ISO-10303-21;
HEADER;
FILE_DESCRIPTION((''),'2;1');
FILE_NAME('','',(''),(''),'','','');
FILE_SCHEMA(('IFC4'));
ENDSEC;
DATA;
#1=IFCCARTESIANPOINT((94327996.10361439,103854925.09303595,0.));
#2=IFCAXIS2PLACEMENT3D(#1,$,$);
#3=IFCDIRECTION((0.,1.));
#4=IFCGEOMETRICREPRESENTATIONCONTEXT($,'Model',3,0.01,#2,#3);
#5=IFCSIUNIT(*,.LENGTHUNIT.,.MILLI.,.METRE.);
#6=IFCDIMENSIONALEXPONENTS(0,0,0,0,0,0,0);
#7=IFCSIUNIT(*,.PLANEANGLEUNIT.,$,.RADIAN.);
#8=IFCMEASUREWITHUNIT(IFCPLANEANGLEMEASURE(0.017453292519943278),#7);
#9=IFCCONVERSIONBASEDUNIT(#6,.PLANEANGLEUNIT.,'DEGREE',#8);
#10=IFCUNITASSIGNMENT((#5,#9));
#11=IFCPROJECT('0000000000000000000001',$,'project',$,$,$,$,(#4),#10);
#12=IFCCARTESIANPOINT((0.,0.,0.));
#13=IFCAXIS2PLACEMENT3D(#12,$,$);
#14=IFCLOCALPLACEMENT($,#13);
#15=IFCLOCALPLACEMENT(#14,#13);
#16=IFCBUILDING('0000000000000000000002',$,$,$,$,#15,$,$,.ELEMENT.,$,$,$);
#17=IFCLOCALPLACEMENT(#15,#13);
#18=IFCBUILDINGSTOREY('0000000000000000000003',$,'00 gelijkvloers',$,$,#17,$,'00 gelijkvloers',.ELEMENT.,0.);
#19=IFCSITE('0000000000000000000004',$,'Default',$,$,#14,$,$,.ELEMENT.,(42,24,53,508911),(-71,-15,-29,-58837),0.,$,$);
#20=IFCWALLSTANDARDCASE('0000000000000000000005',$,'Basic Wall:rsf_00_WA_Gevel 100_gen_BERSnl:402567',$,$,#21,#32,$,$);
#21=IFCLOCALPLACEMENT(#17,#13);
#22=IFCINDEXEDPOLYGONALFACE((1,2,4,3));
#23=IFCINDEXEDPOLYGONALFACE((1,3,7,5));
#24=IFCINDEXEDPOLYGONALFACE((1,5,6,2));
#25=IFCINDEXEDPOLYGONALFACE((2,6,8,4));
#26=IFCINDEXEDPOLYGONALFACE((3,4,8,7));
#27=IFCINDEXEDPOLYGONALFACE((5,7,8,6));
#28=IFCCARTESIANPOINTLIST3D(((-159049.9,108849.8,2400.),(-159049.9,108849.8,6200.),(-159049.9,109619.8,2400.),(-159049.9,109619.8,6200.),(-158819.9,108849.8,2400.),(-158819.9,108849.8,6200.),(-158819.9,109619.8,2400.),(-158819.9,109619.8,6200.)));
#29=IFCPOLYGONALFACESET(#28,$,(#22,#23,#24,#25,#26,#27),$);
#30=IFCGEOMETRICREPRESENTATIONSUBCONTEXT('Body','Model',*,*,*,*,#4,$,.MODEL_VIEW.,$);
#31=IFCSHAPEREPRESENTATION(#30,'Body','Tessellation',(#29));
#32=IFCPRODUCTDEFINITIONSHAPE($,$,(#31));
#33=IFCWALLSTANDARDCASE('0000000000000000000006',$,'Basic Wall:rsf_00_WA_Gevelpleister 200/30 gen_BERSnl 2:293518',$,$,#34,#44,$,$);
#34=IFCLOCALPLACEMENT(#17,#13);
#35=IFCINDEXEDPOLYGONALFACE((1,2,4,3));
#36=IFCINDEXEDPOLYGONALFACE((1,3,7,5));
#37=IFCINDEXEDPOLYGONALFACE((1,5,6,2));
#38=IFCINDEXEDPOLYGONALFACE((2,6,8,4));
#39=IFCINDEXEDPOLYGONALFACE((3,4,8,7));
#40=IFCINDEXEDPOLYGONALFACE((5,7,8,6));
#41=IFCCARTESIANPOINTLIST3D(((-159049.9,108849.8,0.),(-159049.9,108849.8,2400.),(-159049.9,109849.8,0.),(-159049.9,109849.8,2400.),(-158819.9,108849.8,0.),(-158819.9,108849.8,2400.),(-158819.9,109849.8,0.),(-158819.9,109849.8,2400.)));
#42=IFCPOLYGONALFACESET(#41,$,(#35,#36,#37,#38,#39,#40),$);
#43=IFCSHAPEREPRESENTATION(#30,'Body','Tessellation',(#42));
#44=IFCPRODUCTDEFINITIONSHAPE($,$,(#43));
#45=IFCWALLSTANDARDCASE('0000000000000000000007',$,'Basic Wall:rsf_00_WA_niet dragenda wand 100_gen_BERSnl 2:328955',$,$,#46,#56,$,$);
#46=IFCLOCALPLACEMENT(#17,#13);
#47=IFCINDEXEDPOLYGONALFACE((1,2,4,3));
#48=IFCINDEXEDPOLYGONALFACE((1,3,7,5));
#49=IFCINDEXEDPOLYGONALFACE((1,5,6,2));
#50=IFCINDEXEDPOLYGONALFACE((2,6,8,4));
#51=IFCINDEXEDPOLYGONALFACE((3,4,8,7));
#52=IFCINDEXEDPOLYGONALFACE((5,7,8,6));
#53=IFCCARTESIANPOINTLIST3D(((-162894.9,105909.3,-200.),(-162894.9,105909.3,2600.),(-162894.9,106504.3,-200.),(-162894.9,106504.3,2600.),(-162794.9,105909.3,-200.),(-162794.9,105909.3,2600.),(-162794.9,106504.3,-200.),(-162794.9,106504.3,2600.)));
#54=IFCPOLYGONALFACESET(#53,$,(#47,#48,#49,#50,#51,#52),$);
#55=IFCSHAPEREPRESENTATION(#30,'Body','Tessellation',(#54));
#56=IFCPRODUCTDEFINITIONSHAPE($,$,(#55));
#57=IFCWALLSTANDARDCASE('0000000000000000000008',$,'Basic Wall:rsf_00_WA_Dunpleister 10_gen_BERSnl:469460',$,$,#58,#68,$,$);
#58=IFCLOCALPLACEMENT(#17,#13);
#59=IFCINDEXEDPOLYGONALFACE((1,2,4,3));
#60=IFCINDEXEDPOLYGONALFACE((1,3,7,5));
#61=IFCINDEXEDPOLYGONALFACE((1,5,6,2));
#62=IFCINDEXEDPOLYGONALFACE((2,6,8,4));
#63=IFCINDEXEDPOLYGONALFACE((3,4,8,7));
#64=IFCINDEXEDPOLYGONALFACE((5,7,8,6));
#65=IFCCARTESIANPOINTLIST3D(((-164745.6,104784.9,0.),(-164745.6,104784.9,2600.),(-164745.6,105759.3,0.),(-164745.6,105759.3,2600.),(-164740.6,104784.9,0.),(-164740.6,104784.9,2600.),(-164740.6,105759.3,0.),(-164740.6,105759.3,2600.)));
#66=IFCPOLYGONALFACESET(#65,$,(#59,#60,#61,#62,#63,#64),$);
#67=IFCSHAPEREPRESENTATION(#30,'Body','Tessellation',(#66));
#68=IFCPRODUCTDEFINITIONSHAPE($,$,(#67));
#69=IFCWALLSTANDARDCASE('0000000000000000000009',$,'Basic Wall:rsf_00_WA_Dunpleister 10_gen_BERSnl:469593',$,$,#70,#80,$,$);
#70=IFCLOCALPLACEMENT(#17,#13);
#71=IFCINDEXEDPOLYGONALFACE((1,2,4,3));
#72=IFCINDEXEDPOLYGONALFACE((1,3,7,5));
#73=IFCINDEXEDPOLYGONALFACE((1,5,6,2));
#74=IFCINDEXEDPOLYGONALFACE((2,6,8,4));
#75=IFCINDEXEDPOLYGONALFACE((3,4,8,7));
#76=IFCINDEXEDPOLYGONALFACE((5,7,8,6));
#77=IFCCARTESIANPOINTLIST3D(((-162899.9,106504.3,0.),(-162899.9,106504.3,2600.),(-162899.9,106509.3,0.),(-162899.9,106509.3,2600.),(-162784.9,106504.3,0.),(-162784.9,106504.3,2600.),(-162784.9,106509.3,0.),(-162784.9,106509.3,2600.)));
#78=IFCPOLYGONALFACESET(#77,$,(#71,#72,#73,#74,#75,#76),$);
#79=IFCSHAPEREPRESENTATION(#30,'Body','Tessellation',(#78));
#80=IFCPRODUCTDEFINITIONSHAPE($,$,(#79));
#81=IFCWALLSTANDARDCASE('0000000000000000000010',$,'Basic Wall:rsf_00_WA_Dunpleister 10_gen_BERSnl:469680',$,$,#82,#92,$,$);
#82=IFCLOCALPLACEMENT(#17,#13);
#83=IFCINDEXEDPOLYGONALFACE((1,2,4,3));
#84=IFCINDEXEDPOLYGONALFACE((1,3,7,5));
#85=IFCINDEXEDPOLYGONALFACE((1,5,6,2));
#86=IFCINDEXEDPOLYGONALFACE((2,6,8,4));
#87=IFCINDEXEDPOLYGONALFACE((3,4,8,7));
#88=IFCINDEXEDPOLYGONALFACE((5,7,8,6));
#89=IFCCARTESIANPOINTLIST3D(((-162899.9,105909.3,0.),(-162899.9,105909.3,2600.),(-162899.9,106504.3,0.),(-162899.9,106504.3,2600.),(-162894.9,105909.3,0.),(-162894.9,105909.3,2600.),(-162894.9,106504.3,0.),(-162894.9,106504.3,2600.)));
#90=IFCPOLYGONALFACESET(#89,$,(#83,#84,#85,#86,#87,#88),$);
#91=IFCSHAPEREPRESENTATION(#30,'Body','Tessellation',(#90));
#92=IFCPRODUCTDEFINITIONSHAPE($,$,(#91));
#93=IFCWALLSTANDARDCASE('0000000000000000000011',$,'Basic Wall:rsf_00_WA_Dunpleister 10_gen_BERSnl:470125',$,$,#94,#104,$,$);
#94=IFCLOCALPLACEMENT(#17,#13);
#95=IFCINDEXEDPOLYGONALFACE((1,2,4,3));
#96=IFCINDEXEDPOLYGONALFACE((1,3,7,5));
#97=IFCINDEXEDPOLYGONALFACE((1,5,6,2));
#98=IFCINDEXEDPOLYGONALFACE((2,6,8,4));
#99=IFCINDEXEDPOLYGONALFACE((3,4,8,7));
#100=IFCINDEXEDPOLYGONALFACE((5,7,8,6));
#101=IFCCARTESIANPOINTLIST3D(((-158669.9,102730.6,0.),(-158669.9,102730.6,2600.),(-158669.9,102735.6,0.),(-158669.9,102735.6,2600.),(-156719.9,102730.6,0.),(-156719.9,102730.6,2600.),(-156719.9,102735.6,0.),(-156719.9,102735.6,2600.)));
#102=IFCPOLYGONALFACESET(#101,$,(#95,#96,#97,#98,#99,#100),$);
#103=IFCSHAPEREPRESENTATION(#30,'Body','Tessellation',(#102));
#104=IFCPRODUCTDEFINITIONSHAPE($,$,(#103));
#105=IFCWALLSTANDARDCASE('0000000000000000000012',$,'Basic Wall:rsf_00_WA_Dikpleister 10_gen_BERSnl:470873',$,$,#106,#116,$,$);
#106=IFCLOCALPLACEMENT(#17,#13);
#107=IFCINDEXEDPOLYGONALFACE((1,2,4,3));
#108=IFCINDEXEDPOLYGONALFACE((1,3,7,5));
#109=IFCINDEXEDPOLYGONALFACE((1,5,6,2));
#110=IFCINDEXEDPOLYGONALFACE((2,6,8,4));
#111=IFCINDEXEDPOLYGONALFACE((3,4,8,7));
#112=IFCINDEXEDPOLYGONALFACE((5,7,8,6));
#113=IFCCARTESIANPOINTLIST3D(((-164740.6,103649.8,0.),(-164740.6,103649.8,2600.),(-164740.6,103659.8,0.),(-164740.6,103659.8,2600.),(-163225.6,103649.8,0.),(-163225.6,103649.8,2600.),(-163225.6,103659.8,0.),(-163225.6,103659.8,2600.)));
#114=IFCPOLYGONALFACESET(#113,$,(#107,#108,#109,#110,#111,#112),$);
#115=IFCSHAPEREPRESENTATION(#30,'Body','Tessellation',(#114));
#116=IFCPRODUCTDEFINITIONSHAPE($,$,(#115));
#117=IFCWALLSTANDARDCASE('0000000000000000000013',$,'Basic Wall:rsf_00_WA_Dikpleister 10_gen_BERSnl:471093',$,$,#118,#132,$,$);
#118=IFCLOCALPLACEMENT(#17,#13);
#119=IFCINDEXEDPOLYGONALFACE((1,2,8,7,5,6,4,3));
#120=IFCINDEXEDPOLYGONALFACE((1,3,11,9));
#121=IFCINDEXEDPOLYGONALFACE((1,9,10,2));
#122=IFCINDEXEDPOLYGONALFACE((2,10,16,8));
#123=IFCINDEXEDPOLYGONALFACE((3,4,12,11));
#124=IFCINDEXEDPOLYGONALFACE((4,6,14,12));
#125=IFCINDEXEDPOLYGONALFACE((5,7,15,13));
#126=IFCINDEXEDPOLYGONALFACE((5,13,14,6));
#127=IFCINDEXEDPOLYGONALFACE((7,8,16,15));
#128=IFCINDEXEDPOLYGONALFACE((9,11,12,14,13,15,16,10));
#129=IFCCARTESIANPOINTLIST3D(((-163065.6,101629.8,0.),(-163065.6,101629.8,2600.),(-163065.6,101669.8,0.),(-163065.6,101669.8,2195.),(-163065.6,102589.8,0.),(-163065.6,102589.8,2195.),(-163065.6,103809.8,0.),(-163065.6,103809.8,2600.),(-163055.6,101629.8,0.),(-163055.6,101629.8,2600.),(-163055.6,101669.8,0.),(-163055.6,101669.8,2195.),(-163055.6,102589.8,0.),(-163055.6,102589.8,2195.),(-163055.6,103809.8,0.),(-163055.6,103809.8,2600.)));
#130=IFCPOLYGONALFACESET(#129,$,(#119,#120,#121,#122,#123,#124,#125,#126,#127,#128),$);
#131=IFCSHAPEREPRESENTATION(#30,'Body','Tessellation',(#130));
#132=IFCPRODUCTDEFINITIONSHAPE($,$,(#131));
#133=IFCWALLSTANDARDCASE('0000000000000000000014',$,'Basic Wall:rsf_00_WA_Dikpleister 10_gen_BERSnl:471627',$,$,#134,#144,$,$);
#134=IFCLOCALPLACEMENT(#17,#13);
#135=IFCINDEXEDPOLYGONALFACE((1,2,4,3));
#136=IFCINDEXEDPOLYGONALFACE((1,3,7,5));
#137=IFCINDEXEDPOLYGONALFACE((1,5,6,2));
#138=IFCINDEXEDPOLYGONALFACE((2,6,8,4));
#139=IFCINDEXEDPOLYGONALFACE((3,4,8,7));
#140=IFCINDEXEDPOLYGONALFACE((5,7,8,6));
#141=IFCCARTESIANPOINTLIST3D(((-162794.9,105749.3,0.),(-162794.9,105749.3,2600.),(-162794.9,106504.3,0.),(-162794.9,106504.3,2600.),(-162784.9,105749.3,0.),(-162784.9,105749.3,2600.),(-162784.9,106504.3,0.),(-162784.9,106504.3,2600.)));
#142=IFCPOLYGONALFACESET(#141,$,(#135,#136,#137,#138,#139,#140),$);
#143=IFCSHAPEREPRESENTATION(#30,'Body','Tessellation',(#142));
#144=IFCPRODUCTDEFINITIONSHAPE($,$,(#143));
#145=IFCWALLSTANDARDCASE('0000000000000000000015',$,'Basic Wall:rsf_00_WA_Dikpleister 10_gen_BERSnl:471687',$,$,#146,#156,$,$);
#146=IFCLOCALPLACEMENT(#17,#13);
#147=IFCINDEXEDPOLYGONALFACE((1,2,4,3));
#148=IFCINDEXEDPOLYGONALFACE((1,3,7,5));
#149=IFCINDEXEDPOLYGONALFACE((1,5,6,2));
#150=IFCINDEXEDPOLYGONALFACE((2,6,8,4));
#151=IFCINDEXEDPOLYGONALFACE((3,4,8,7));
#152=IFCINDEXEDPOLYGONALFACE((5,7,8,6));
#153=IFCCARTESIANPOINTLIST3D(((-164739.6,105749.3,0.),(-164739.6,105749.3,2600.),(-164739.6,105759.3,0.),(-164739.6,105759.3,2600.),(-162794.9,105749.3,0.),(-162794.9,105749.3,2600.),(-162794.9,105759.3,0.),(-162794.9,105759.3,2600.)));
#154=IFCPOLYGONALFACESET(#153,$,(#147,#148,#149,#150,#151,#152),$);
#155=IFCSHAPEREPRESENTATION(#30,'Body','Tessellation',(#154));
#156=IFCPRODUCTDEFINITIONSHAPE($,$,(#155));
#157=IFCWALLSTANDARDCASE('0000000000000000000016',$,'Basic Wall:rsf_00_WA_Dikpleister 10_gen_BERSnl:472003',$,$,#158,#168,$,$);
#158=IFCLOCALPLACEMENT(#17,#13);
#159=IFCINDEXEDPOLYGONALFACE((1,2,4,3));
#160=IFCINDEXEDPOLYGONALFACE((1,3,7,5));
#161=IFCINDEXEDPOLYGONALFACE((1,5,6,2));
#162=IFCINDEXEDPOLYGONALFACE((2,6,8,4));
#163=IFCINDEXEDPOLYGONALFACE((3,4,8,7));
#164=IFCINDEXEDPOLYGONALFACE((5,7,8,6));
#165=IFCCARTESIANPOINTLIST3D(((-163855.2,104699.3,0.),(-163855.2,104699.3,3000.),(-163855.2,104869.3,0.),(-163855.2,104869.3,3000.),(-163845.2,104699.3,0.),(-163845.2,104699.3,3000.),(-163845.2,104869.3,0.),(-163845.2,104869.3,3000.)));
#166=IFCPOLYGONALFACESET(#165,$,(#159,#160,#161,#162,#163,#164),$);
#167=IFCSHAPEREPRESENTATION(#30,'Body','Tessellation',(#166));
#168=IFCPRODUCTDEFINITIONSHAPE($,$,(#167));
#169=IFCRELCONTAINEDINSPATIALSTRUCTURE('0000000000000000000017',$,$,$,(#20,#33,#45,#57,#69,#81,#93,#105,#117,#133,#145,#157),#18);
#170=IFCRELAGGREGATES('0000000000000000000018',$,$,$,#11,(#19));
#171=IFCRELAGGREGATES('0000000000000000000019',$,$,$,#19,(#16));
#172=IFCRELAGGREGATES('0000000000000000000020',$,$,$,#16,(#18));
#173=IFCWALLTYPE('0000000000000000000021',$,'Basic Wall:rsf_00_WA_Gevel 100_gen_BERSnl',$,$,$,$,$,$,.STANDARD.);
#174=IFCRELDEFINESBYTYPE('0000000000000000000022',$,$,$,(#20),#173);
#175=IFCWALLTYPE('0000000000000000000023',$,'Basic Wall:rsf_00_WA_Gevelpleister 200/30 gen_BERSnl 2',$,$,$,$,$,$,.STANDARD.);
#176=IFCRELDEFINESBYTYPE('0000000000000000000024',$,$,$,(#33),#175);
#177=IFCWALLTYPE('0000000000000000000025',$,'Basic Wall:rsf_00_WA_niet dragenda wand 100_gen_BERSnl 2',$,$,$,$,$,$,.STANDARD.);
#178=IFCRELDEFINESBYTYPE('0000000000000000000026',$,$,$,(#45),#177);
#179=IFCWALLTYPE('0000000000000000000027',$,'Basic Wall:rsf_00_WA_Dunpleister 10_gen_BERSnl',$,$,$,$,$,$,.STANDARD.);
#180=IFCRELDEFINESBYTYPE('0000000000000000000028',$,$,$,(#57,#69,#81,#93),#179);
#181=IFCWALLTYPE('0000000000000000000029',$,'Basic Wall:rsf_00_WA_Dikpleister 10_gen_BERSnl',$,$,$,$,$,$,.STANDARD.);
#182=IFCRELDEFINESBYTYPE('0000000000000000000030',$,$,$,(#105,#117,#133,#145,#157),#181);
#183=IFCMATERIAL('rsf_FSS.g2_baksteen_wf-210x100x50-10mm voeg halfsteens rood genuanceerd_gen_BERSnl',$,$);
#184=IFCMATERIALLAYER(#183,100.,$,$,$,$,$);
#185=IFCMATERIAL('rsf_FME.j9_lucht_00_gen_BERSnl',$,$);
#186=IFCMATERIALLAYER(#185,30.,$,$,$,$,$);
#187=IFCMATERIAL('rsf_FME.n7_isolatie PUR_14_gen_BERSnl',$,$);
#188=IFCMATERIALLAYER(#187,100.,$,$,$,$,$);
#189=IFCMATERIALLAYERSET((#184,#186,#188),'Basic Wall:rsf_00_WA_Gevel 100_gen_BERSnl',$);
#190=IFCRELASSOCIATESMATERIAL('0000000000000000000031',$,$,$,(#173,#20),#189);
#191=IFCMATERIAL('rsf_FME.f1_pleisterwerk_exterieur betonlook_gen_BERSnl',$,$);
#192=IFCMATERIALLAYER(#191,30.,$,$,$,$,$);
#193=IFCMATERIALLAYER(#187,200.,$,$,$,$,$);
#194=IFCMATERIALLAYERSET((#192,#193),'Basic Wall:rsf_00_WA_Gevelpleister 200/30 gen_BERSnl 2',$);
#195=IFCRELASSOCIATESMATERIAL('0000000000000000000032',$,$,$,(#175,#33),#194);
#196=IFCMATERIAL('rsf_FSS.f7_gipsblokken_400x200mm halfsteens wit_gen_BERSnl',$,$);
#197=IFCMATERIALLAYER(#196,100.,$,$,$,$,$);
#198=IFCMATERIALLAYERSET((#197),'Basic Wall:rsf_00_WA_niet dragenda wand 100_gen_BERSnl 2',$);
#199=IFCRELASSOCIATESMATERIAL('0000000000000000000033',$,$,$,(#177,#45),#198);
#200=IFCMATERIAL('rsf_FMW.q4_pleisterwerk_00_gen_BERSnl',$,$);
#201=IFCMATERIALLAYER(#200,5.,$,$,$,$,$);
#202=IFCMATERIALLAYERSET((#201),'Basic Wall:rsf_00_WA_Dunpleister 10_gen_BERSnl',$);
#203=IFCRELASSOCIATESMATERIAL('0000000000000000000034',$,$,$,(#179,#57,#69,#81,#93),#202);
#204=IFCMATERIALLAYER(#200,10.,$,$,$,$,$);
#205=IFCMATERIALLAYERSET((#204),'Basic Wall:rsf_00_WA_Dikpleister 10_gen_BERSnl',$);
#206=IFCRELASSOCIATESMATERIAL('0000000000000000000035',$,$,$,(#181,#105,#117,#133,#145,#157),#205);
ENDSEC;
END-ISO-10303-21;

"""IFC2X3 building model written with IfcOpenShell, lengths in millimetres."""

from ifc_helpers import new_model, entity, si_unit, converted_unit, direction, frame, frame_2d, origin, place, context, subcontext, project, spatial, rectangle, extrude, material, layer, layer_set, layer_usage, type_object, element, save


model = new_model("IFC2X3")

# Units and contexts
model_context = context("Model", 3, precision=0.01, world=frame((94327996.10361439, 103854925.09303595, 0.0)), true_north=direction((0.0, 1.0)))
body_context = subcontext(model_context, "Body", "Model", "MODEL_VIEW")
ifc_project = project(units=[si_unit("LENGTHUNIT", "METRE", prefix="MILLI"), converted_unit("PLANEANGLEUNIT", "DEGREE", entity("IfcPlaneAngleMeasure", 0.017453292519943278), si_unit("PLANEANGLEUNIT", "RADIAN"), dimensions=[0, 0, 0, 0, 0, 0, 0])], contexts=[model_context])

# Site, building, storey
site_placement = place(None, origin())
site = spatial("IfcSite", under=ifc_project, at=site_placement, Name="Default", CompositionType="ELEMENT", RefLatitude=(42, 24, 53, 508911), RefLongitude=(-71, -15, -29, -58837), RefElevation=0.0)
building_placement = place(site_placement, origin())
building = spatial("IfcBuilding", under=site, at=building_placement, CompositionType="ELEMENT")
storey_placement = place(building_placement, origin())
storey = spatial("IfcBuildingStorey", under=building, at=storey_placement, Name="00 gelijkvloers", LongName="00 gelijkvloers", CompositionType="ELEMENT", Elevation=0.0)

# Walls
ifc_material_1 = material(Name="rsf_FSS.g2_baksteen_wf-210x100x50-10mm voeg halfsteens rood genuanceerd_gen_BERSnl")
ifc_layer_1 = layer(ifc_material_1, 100.0)
ifc_material_2 = material(Name="rsf_FME.j9_lucht_00_gen_BERSnl")
ifc_layer_2 = layer(ifc_material_2, 30.0)
ifc_material_3 = material(Name="rsf_FME.n7_isolatie PUR_14_gen_BERSnl")
ifc_layer_3 = layer(ifc_material_3, 100.0)
ifc_layer_set_1 = layer_set([ifc_layer_1, ifc_layer_2, ifc_layer_3], Name="Basic Wall:rsf_00_WA_Gevel 100_gen_BERSnl")
ifc_layer_usage_1 = layer_usage(ifc_layer_set_1, "AXIS2", "NEGATIVE", 115.0)
wall_type_1 = type_object("IfcWallType", Name="Basic Wall:rsf_00_WA_Gevel 100_gen_BERSnl", PredefinedType="STANDARD", material=ifc_layer_set_1)
wall_1_placement = place(storey_placement, frame((-158934.9, 108849.8, 2400.0), z_axis=(0.0, 0.0, 1.0), x_axis=(0.0, 1.0, 0.0)))
element("IfcWallStandardCase", 1, at=wall_1_placement, inside=storey, type_object=wall_type_1, material=ifc_layer_usage_1, Name="Basic Wall:rsf_00_WA_Gevel 100_gen_BERSnl:402567", context=body_context, shape_type="SweptSolid", body=[
    extrude(rectangle(XDim=769.9, YDim=230.0, at=frame_2d((385.0, 0.0), x_axis=(-1.0, 0.0))), origin(), (0.0, 0.0, 1.0), 3800.0),
])
ifc_material_4 = material(Name="rsf_FME.f1_pleisterwerk_exterieur betonlook_gen_BERSnl")
ifc_layer_4 = layer(ifc_material_4, 30.0)
ifc_layer_5 = layer(ifc_material_3, 200.0)
ifc_layer_set_2 = layer_set([ifc_layer_4, ifc_layer_5], Name="Basic Wall:rsf_00_WA_Gevelpleister 200/30 gen_BERSnl 2")
ifc_layer_usage_2 = layer_usage(ifc_layer_set_2, "AXIS2", "NEGATIVE", 115.0)
wall_type_2 = type_object("IfcWallType", Name="Basic Wall:rsf_00_WA_Gevelpleister 200/30 gen_BERSnl 2", PredefinedType="STANDARD", material=ifc_layer_set_2)
wall_2_placement = place(storey_placement, frame((-158934.9, 108849.8, 0.0), z_axis=(0.0, 0.0, 1.0), x_axis=(0.0, 1.0, 0.0)))
element("IfcWallStandardCase", 2, at=wall_2_placement, inside=storey, type_object=wall_type_2, material=ifc_layer_usage_2, Name="Basic Wall:rsf_00_WA_Gevelpleister 200/30 gen_BERSnl 2:293518", context=body_context, shape_type="SweptSolid", body=[
    extrude(rectangle(XDim=999.9, YDim=230.0, at=frame_2d((500.0, 0.0), x_axis=(-1.0, 0.0))), origin(), (0.0, 0.0, 1.0), 2400.0),
])
ifc_material_5 = material(Name="rsf_FSS.f7_gipsblokken_400x200mm halfsteens wit_gen_BERSnl")
ifc_layer_6 = layer(ifc_material_5, 100.0)
ifc_layer_set_3 = layer_set([ifc_layer_6], Name="Basic Wall:rsf_00_WA_niet dragenda wand 100_gen_BERSnl 2")
ifc_layer_usage_3 = layer_usage(ifc_layer_set_3, "AXIS2", "NEGATIVE", 50.0)
wall_type_3 = type_object("IfcWallType", Name="Basic Wall:rsf_00_WA_niet dragenda wand 100_gen_BERSnl 2", PredefinedType="STANDARD", material=ifc_layer_set_3)
wall_3_placement = place(storey_placement, frame((-162844.9, 105909.3, -200.0), z_axis=(0.0, 0.0, 1.0), x_axis=(0.0, 1.0, 0.0)))
element("IfcWallStandardCase", 3, at=wall_3_placement, inside=storey, type_object=wall_type_3, material=ifc_layer_usage_3, Name="Basic Wall:rsf_00_WA_niet dragenda wand 100_gen_BERSnl 2:328955", context=body_context, shape_type="SweptSolid", body=[
    extrude(rectangle(XDim=595.0, YDim=100.0, at=frame_2d((297.5, 0.0), x_axis=(-1.0, 0.0))), origin(), (0.0, 0.0, 1.0), 2800.0),
])
ifc_material_6 = material(Name="rsf_FMW.q4_pleisterwerk_00_gen_BERSnl")
ifc_layer_7 = layer(ifc_material_6, 5.0)
ifc_layer_set_4 = layer_set([ifc_layer_7], Name="Basic Wall:rsf_00_WA_Dunpleister 10_gen_BERSnl")
ifc_layer_usage_4 = layer_usage(ifc_layer_set_4, "AXIS2", "NEGATIVE", 2.5)
wall_type_4 = type_object("IfcWallType", Name="Basic Wall:rsf_00_WA_Dunpleister 10_gen_BERSnl", PredefinedType="STANDARD", material=ifc_layer_set_4)
wall_4_placement = place(storey_placement, frame((-164743.1, 105759.3, 0.0), z_axis=(0.0, 0.0, 1.0), x_axis=(0.0, -1.0, 0.0)))
element("IfcWallStandardCase", 4, at=wall_4_placement, inside=storey, type_object=wall_type_4, material=ifc_layer_usage_4, Name="Basic Wall:rsf_00_WA_Dunpleister 10_gen_BERSnl:469460", context=body_context, shape_type="SweptSolid", body=[
    extrude(rectangle(XDim=974.4, YDim=5.0, at=frame_2d((487.2, 0.0), x_axis=(-1.0, 0.0))), origin(), (0.0, 0.0, 1.0), 2600.0),
])
ifc_layer_usage_5 = layer_usage(ifc_layer_set_4, "AXIS2", "NEGATIVE", 2.5)
wall_5_placement = place(storey_placement, frame((-162784.9, 106506.8, 0.0), z_axis=(0.0, 0.0, 1.0), x_axis=(-1.0, 0.0, 0.0)))
element("IfcWallStandardCase", 5, at=wall_5_placement, inside=storey, type_object=wall_type_4, material=ifc_layer_usage_5, Name="Basic Wall:rsf_00_WA_Dunpleister 10_gen_BERSnl:469593", context=body_context, shape_type="SweptSolid", body=[
    extrude(rectangle(XDim=115.0, YDim=5.0, at=frame_2d((57.5, 0.0), x_axis=(-1.0, 0.0))), origin(), (0.0, 0.0, 1.0), 2600.0),
])
ifc_layer_usage_6 = layer_usage(ifc_layer_set_4, "AXIS2", "POSITIVE", -2.5)
wall_6_placement = place(storey_placement, frame((-162897.4, 106504.3, 0.0), z_axis=(0.0, 0.0, 1.0), x_axis=(0.0, -1.0, 0.0)))
element("IfcWallStandardCase", 6, at=wall_6_placement, inside=storey, type_object=wall_type_4, material=ifc_layer_usage_6, Name="Basic Wall:rsf_00_WA_Dunpleister 10_gen_BERSnl:469680", context=body_context, shape_type="SweptSolid", body=[
    extrude(rectangle(XDim=595.0, YDim=5.0, at=frame_2d((297.5, 0.0), x_axis=(-1.0, 0.0))), origin(), (0.0, 0.0, 1.0), 2600.0),
])
ifc_layer_usage_7 = layer_usage(ifc_layer_set_4, "AXIS2", "NEGATIVE", 2.5)
wall_7_placement = place(storey_placement, frame((-158669.9, 102733.1, 0.0)))
element("IfcWallStandardCase", 7, at=wall_7_placement, inside=storey, type_object=wall_type_4, material=ifc_layer_usage_7, Name="Basic Wall:rsf_00_WA_Dunpleister 10_gen_BERSnl:470125", context=body_context, shape_type="SweptSolid", body=[
    extrude(rectangle(XDim=1950.0, YDim=5.0, at=frame_2d((975.0, 0.0), x_axis=(-1.0, 0.0))), origin(), (0.0, 0.0, 1.0), 2600.0),
])
ifc_layer_8 = layer(ifc_material_6, 10.0)
ifc_layer_set_5 = layer_set([ifc_layer_8], Name="Basic Wall:rsf_00_WA_Dikpleister 10_gen_BERSnl")
ifc_layer_usage_8 = layer_usage(ifc_layer_set_5, "AXIS2", "NEGATIVE", 5.0)
wall_type_5 = type_object("IfcWallType", Name="Basic Wall:rsf_00_WA_Dikpleister 10_gen_BERSnl", PredefinedType="STANDARD", material=ifc_layer_set_5)
wall_8_placement = place(storey_placement, frame((-163225.6, 103654.8, 0.0), z_axis=(0.0, 0.0, 1.0), x_axis=(-1.0, 0.0, 0.0)))
element("IfcWallStandardCase", 8, at=wall_8_placement, inside=storey, type_object=wall_type_5, material=ifc_layer_usage_8, Name="Basic Wall:rsf_00_WA_Dikpleister 10_gen_BERSnl:470873", context=body_context, shape_type="SweptSolid", body=[
    extrude(rectangle(XDim=1515.0, YDim=10.0, at=frame_2d((757.5, 0.0), x_axis=(-1.0, 0.0))), origin(), (0.0, 0.0, 1.0), 2600.0),
])

# Wall, opening
ifc_layer_usage_9 = layer_usage(ifc_layer_set_5, "AXIS2", "NEGATIVE", 5.0)
wall_9_placement = place(storey_placement, frame((-163060.6, 103809.8, 0.0), z_axis=(0.0, 0.0, 1.0), x_axis=(0.0, -1.0, 0.0)))
wall_9 = element("IfcWallStandardCase", 9, at=wall_9_placement, inside=storey, type_object=wall_type_5, material=ifc_layer_usage_9, Name="Basic Wall:rsf_00_WA_Dikpleister 10_gen_BERSnl:471093", context=body_context, shape_type="SweptSolid", body=[
    extrude(rectangle(XDim=2180.0, YDim=10.0, at=frame_2d((1090.0, 0.0), x_axis=(-1.0, 0.0))), origin(), (0.0, 0.0, 1.0), 2600.0),
])
opening_1_placement = place(wall_9_placement, frame((1220.0, -5.0, -180.0)))
element("IfcOpeningElement", 10, at=opening_1_placement, cuts=wall_9, ObjectType="Opening", context=body_context, shape_type="SweptSolid", body=[
    extrude(rectangle(XDim=2375.0, YDim=920.0, at=frame_2d((1187.5, 460.0), x_axis=(-1.0, 0.0))), frame((0.0, 0.0, 0.0), z_axis=(0.0, 1.0, 0.0), x_axis=(0.0, 0.0, 1.0)), (0.0, 0.0, 1.0), 10.0),
])

# Walls
ifc_layer_usage_10 = layer_usage(ifc_layer_set_5, "AXIS2", "NEGATIVE", 5.0)
wall_10_placement = place(storey_placement, frame((-162789.9, 106504.3, 0.0), z_axis=(0.0, 0.0, 1.0), x_axis=(0.0, -1.0, 0.0)))
element("IfcWallStandardCase", 11, at=wall_10_placement, inside=storey, type_object=wall_type_5, material=ifc_layer_usage_10, Name="Basic Wall:rsf_00_WA_Dikpleister 10_gen_BERSnl:471627", context=body_context, shape_type="SweptSolid", body=[
    extrude(rectangle(XDim=755.0, YDim=10.0, at=frame_2d((377.5, 0.0), x_axis=(-1.0, 0.0))), origin(), (0.0, 0.0, 1.0), 2600.0),
])
ifc_layer_usage_11 = layer_usage(ifc_layer_set_5, "AXIS2", "NEGATIVE", 5.0)
wall_11_placement = place(storey_placement, frame((-162794.9, 105754.3, 0.0), z_axis=(0.0, 0.0, 1.0), x_axis=(-1.0, 0.0, 0.0)))
element("IfcWallStandardCase", 12, at=wall_11_placement, inside=storey, type_object=wall_type_5, material=ifc_layer_usage_11, Name="Basic Wall:rsf_00_WA_Dikpleister 10_gen_BERSnl:471687", context=body_context, shape_type="SweptSolid", body=[
    extrude(rectangle(XDim=1944.7, YDim=10.0, at=frame_2d((972.4, 0.0), x_axis=(-1.0, 0.0))), origin(), (0.0, 0.0, 1.0), 2600.0),
])
ifc_layer_usage_12 = layer_usage(ifc_layer_set_5, "AXIS2", "NEGATIVE", 5.0)
wall_12_placement = place(storey_placement, frame((-163850.2, 104699.3, 0.0), z_axis=(0.0, 0.0, 1.0), x_axis=(0.0, 1.0, 0.0)))
element("IfcWallStandardCase", 13, at=wall_12_placement, inside=storey, type_object=wall_type_5, material=ifc_layer_usage_12, Name="Basic Wall:rsf_00_WA_Dikpleister 10_gen_BERSnl:472003", context=body_context, shape_type="SweptSolid", body=[
    extrude(rectangle(XDim=170.0, YDim=10.0, at=frame_2d((85.0, 0.0), x_axis=(-1.0, 0.0))), origin(), (0.0, 0.0, 1.0), 3000.0),
])

save(model, "model.ifc")
